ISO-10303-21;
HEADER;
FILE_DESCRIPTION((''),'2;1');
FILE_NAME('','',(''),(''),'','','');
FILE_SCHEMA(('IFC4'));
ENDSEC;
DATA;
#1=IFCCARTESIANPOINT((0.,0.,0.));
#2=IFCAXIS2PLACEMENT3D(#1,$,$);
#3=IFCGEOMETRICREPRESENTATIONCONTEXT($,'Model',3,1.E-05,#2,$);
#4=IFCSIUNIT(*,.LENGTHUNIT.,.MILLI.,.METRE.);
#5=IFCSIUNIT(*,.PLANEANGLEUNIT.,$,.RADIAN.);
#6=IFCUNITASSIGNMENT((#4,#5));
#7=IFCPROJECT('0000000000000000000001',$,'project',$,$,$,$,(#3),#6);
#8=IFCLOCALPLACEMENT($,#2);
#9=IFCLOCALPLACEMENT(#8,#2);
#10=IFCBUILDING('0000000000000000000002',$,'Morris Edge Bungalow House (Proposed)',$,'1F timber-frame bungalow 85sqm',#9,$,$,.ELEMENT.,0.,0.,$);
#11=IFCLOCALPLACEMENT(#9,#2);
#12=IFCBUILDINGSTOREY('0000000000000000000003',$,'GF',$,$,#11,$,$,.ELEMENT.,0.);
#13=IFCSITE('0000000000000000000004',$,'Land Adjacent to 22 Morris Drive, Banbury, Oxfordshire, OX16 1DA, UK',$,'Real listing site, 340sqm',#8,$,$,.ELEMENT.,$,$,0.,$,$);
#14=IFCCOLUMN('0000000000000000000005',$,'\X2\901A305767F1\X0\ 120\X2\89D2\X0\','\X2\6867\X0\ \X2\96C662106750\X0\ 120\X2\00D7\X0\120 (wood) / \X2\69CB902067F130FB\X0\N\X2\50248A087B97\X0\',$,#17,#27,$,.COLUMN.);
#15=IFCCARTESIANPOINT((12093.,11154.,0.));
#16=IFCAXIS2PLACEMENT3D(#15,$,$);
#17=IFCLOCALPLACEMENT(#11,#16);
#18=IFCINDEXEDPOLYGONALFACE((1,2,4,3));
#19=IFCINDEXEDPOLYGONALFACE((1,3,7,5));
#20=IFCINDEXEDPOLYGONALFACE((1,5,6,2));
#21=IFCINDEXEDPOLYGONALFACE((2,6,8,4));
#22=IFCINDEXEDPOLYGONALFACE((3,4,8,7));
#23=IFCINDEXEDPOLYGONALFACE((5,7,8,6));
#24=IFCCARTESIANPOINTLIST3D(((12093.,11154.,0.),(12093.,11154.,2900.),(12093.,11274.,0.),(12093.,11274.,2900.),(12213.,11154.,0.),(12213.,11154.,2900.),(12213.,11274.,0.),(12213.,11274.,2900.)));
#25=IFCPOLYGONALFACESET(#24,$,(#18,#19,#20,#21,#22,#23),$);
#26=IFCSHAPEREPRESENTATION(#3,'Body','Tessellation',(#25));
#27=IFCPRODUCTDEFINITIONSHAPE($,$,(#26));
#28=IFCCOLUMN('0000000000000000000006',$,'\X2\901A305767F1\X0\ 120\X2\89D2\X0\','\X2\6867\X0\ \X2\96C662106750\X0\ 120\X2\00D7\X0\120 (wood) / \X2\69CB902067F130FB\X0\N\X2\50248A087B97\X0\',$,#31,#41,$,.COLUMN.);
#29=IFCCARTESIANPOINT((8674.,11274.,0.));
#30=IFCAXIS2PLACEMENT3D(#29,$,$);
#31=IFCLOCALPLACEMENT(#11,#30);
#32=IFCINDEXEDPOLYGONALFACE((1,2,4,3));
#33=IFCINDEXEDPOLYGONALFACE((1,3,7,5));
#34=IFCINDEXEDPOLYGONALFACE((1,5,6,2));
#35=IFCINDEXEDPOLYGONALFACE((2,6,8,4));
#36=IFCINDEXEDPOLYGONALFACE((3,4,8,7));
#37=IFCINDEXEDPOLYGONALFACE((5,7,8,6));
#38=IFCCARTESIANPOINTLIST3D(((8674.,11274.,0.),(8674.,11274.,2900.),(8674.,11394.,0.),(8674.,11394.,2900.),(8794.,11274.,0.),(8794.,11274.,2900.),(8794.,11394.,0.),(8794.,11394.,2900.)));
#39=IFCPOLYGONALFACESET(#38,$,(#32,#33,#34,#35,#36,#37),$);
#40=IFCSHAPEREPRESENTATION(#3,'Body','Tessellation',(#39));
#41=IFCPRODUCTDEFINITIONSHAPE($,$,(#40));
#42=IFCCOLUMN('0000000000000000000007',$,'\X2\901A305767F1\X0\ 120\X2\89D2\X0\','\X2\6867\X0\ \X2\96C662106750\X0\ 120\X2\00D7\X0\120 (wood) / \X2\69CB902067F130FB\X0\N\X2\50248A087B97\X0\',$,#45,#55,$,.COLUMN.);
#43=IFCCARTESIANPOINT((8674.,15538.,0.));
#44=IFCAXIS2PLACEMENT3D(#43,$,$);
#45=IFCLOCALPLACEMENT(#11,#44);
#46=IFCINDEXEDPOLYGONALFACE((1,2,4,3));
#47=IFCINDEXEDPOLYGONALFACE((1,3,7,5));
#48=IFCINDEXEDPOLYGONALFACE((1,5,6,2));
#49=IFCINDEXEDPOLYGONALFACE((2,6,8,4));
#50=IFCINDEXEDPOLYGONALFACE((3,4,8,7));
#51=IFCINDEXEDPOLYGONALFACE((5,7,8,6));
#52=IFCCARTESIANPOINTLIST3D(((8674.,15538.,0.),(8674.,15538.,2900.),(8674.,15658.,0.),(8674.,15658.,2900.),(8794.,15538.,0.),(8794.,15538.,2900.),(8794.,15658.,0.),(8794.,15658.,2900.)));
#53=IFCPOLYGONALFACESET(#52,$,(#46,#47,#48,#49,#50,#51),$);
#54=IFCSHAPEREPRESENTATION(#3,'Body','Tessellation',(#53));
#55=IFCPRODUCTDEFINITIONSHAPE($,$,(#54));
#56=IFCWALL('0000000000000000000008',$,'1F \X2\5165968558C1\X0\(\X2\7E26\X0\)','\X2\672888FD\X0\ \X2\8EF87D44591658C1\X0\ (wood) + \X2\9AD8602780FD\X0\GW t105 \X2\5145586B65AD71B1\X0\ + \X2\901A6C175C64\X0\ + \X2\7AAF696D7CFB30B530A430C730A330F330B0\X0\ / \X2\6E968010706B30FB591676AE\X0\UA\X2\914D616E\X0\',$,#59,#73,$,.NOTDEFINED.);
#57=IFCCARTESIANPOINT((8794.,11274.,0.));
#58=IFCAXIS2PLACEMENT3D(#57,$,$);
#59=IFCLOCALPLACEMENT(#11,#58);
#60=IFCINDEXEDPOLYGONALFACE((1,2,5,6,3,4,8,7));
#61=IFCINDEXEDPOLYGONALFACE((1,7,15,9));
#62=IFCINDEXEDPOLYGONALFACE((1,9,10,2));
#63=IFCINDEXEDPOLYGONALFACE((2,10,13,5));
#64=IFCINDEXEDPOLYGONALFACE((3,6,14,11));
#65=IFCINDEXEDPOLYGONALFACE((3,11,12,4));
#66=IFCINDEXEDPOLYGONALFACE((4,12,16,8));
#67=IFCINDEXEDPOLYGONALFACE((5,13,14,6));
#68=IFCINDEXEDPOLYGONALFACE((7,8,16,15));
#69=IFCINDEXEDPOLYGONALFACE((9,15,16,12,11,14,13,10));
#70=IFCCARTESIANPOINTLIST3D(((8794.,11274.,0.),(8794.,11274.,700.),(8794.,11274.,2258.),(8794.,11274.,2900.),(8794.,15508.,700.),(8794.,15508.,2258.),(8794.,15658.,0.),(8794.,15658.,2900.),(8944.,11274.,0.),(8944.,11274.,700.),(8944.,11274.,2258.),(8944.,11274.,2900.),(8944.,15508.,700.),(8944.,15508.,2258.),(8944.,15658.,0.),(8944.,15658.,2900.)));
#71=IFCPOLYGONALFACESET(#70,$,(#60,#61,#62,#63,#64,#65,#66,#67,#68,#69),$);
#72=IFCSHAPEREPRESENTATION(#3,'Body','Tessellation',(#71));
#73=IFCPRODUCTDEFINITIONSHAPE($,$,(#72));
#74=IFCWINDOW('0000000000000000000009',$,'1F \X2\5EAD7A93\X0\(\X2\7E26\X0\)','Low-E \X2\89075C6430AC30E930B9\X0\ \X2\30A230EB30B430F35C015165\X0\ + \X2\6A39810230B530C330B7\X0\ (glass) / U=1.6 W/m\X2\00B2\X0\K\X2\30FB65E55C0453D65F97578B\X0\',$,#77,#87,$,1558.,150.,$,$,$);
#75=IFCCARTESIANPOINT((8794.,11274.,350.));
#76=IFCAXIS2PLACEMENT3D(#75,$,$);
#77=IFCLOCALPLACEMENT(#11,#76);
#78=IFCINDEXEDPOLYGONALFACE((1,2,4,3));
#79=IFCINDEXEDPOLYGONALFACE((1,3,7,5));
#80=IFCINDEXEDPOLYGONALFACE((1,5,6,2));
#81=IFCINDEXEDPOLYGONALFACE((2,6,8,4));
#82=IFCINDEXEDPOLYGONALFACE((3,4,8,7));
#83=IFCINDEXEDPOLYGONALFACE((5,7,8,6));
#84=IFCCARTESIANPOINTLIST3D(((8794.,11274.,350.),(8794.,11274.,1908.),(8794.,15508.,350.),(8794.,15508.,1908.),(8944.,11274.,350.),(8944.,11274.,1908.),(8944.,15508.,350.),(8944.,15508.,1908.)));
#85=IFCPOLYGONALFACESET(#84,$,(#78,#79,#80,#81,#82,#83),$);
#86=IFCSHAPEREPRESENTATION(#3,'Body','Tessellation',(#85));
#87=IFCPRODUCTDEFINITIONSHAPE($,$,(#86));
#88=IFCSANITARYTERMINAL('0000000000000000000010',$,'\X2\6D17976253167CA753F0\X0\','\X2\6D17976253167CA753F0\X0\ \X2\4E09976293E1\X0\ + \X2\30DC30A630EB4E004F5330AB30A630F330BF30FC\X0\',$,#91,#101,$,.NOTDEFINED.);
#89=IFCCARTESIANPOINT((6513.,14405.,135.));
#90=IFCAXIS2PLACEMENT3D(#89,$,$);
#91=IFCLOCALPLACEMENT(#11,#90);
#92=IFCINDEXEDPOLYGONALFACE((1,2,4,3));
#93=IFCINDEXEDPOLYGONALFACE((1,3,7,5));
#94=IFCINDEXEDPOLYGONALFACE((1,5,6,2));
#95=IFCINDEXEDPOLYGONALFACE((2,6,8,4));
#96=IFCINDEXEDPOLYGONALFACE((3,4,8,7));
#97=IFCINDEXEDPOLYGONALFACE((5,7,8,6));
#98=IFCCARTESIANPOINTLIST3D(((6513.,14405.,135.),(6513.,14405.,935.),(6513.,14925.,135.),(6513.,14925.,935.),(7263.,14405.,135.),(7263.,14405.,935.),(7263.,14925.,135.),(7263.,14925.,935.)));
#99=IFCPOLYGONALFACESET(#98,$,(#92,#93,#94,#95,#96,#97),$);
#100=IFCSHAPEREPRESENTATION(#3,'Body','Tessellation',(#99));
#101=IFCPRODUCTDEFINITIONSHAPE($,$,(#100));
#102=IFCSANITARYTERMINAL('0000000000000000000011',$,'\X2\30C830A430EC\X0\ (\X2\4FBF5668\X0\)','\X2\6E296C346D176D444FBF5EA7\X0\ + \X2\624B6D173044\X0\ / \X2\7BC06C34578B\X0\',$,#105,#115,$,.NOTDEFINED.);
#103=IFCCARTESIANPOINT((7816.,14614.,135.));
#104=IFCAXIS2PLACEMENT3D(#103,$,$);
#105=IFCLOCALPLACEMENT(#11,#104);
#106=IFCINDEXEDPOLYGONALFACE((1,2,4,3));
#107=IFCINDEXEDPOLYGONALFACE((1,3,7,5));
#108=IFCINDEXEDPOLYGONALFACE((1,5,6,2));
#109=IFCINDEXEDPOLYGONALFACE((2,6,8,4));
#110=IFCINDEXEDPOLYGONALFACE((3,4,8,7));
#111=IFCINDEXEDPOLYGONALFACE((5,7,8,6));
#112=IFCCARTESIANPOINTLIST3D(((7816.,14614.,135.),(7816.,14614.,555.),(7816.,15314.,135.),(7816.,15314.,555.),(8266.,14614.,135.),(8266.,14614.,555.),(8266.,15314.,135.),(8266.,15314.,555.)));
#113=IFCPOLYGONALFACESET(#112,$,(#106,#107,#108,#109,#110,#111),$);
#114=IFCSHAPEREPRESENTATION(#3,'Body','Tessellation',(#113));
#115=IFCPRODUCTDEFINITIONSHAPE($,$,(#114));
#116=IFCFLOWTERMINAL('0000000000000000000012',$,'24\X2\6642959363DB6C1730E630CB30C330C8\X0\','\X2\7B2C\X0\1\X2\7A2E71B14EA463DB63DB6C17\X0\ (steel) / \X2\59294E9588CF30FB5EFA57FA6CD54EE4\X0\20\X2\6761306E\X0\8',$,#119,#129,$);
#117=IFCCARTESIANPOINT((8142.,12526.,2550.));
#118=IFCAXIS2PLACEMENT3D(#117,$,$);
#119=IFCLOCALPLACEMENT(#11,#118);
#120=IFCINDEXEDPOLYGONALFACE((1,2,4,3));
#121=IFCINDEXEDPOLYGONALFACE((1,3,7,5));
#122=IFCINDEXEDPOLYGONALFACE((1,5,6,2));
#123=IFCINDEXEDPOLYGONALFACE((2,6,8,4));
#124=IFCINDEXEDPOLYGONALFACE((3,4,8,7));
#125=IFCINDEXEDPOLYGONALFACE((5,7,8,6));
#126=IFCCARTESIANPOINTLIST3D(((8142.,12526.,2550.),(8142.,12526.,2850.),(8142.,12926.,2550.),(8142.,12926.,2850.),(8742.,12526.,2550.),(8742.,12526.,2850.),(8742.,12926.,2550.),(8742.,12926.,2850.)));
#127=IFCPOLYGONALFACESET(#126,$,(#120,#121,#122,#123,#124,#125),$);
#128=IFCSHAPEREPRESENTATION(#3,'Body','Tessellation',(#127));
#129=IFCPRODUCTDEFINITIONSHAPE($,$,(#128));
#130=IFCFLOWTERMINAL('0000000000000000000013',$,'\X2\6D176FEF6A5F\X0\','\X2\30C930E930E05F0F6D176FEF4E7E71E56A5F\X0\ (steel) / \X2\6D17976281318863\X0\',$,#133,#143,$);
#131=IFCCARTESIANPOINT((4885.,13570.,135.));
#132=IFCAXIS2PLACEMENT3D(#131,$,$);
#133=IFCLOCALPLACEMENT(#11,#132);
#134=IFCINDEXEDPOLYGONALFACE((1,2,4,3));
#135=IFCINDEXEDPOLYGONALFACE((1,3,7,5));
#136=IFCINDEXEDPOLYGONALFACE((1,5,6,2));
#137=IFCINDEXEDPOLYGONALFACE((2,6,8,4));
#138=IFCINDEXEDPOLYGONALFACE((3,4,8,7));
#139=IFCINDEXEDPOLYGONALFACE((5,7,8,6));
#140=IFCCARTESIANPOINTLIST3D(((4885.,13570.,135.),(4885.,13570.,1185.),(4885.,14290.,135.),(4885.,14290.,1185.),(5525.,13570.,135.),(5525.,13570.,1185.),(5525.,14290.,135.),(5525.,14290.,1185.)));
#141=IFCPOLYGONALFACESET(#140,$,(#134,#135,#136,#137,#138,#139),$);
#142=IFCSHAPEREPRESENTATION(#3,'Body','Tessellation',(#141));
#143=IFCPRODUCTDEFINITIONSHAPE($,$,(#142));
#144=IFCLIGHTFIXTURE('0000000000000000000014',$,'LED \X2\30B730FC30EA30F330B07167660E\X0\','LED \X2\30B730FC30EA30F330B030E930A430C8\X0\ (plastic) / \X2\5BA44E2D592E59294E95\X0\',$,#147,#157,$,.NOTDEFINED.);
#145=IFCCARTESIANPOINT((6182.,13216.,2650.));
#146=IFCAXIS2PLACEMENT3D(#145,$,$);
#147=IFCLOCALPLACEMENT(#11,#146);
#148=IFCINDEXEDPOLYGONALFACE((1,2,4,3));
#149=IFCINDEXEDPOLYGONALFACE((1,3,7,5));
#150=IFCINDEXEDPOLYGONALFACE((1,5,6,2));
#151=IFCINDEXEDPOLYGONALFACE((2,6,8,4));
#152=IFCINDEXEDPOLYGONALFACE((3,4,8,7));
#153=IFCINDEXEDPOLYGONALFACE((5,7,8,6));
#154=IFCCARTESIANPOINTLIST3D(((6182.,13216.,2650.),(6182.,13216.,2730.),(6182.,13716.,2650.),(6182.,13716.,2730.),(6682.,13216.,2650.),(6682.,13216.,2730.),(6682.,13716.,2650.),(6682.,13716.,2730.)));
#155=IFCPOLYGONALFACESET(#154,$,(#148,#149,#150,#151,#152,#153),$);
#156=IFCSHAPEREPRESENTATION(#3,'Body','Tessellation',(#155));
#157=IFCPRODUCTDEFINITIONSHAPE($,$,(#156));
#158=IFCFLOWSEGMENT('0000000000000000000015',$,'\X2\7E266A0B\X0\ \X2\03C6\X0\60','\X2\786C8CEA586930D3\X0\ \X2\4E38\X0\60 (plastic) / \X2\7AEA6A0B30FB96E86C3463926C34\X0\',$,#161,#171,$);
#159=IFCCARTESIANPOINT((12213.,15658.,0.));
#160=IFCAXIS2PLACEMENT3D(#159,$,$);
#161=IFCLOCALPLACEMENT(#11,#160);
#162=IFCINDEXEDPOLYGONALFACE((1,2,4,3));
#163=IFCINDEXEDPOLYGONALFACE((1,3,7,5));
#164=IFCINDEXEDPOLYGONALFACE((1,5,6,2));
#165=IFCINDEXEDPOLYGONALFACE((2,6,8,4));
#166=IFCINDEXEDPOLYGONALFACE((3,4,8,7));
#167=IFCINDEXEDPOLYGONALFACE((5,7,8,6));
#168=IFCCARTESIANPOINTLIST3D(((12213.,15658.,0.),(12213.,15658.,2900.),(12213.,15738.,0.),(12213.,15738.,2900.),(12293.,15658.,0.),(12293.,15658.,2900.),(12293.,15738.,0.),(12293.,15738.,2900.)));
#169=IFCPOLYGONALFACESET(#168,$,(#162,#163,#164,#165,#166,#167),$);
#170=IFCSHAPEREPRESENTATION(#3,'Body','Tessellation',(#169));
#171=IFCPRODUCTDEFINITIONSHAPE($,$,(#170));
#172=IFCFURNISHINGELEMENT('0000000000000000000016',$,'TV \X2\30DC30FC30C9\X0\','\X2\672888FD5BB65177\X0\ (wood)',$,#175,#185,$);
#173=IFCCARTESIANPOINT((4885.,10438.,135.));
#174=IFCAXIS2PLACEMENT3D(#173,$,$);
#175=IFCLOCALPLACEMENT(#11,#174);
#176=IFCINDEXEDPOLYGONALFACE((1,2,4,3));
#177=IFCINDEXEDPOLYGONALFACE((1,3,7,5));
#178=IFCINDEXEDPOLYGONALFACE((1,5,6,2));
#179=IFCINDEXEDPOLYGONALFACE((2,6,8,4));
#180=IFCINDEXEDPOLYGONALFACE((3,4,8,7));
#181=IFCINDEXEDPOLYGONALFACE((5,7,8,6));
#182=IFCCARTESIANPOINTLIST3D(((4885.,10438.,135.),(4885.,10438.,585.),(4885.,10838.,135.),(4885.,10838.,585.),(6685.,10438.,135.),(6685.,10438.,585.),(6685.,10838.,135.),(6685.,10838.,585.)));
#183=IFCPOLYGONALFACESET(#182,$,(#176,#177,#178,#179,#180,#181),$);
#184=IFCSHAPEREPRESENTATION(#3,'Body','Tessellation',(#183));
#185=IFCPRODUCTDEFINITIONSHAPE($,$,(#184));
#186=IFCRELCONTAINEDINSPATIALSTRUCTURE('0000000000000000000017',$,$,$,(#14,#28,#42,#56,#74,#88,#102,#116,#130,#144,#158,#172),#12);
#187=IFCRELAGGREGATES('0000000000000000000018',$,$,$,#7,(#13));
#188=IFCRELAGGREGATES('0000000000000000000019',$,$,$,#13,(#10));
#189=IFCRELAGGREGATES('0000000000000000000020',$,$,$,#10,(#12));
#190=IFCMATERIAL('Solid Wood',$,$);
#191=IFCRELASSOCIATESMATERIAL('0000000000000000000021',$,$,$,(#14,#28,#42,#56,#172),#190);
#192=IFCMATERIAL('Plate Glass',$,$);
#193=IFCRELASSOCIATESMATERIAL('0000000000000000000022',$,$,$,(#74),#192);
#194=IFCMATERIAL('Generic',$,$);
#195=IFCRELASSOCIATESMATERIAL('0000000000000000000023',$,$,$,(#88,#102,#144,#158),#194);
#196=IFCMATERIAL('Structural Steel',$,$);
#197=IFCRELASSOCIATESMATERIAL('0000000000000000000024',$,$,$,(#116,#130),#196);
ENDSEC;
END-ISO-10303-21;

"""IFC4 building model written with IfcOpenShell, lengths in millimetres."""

from ifc_helpers import new_model, si_unit, frame, frame_2d, origin, place, context, project, spatial, rectangle, extrude, material, element, fill, save


model = new_model("IFC4")

# Units and contexts
model_context = context("Model", 3, precision=1e-05, world=origin())
ifc_project = project(units=[si_unit("LENGTHUNIT", "METRE", prefix="MILLI"), si_unit("PLANEANGLEUNIT", "RADIAN")], contexts=[model_context])

# Site, building, storey
site_placement = place(None, origin())
site = spatial("IfcSite", under=ifc_project, at=site_placement, Name="Land Adjacent to 22 Morris Drive, Banbury, Oxfordshire, OX16 1DA, UK", ObjectType="Real listing site, 340sqm", CompositionType="ELEMENT", RefElevation=0.0)
building_placement = place(site_placement, origin())
building = spatial("IfcBuilding", under=site, at=building_placement, Name="Morris Edge Bungalow House (Proposed)", ObjectType="1F timber-frame bungalow 85sqm", CompositionType="ELEMENT", ElevationOfRefHeight=0.0, ElevationOfTerrain=0.0)
storey_placement = place(building_placement, origin())
storey = spatial("IfcBuildingStorey", under=building, at=storey_placement, Name="GF", CompositionType="ELEMENT", Elevation=0.0)

# Columns
ifc_material_1 = material(Name="Solid Wood")
column_1_placement = place(storey_placement, frame((12093.0, 11154.0, 0.0)))
element("IfcColumn", 1, at=column_1_placement, inside=storey, material=ifc_material_1, Name="通し柱 120角", Description="桧 集成材 120×120 (wood) / 構造柱・N値計算", PredefinedType="COLUMN", context=model_context, shape_type="SweptSolid", body=[
    extrude(rectangle(XDim=120.0, YDim=120.0, at=frame_2d((60.0, 60.0))), frame((12093.0, 11154.0, 0.0)), (0.0, 0.0, 1.0), 2900.0),
])
column_2_placement = place(storey_placement, frame((8674.0, 11274.0, 0.0)))
element("IfcColumn", 2, at=column_2_placement, inside=storey, material=ifc_material_1, Name="通し柱 120角", Description="桧 集成材 120×120 (wood) / 構造柱・N値計算", PredefinedType="COLUMN", context=model_context, shape_type="SweptSolid", body=[
    extrude(rectangle(XDim=120.0, YDim=120.0, at=frame_2d((60.0, 60.0))), frame((8674.0, 11274.0, 0.0)), (0.0, 0.0, 1.0), 2900.0),
])
column_3_placement = place(storey_placement, frame((8674.0, 15538.0, 0.0)))
element("IfcColumn", 3, at=column_3_placement, inside=storey, material=ifc_material_1, Name="通し柱 120角", Description="桧 集成材 120×120 (wood) / 構造柱・N値計算", PredefinedType="COLUMN", context=model_context, shape_type="SweptSolid", body=[
    extrude(rectangle(XDim=120.0, YDim=120.0, at=frame_2d((60.0, 60.0))), frame((8674.0, 15538.0, 0.0)), (0.0, 0.0, 1.0), 2900.0),
])

# Wall, opening, window
wall_1_placement = place(storey_placement, frame((8794.0, 11274.0, 0.0)))
wall_1 = element("IfcWall", 4, at=wall_1_placement, inside=storey, material=ifc_material_1, Name="1F 入隅壁(縦)", Description="木製 軸組外壁 (wood) + 高性能GW t105 充填断熱 + 通気層 + 窯業系サイディング / 準耐火・外皮UA配慮", PredefinedType="NOTDEFINED", context=model_context, shape_type="SweptSolid", body=[
    extrude(rectangle(XDim=150.0, YDim=4384.0, at=frame_2d((75.0, 2192.0))), frame((8794.0, 11274.0, 0.0)), (0.0, 0.0, 1.0), 2900.0),
])
opening_placement = place(storey_placement, frame((8794.0, 11274.0, 350.0)))
opening = element("IfcOpeningElement", 5, at=opening_placement, cuts=wall_1, PredefinedType="NOTDEFINED", context=model_context, shape_type="SweptSolid", body=[
    extrude(rectangle(XDim=150.0, YDim=4234.0, at=frame_2d((75.0, 2117.0))), frame((8794.0, 11274.0, 350.0)), (0.0, 0.0, 1.0), 1558.0),
])
ifc_material_2 = material(Name="Plate Glass")
window_placement = place(storey_placement, frame((8794.0, 11274.0, 350.0)))
window = element("IfcWindow", 6, at=window_placement, inside=storey, material=ifc_material_2, Name="1F 庭窓(縦)", Description="Low-E 複層ガラス アルゴン封入 + 樹脂サッシ (glass) / U=1.6 W/m²K・日射取得型", OverallHeight=1558.0, OverallWidth=150.0, context=model_context, shape_type="SweptSolid", body=[
    extrude(rectangle(XDim=150.0, YDim=4234.0, at=frame_2d((75.0, 2117.0))), frame((8794.0, 11274.0, 350.0)), (0.0, 0.0, 1.0), 1558.0),
])
fill(opening, window)

# Sanitary terminals
ifc_material_3 = material(Name="Generic")
sanitary_terminal_1_placement = place(storey_placement, frame((6513.0, 14405.0, 135.0)))
element("IfcSanitaryTerminal", 7, at=sanitary_terminal_1_placement, inside=storey, material=ifc_material_3, Name="洗面化粧台", Description="洗面化粧台 三面鏡 + ボウル一体カウンター", PredefinedType="NOTDEFINED", context=model_context, shape_type="SweptSolid", body=[
    extrude(rectangle(XDim=750.0, YDim=520.0, at=frame_2d((375.0, 260.0))), frame((6513.0, 14405.0, 135.0)), (0.0, 0.0, 1.0), 800.0),
])
sanitary_terminal_2_placement = place(storey_placement, frame((7816.0, 14614.0, 135.0)))
element("IfcSanitaryTerminal", 8, at=sanitary_terminal_2_placement, inside=storey, material=ifc_material_3, Name="トイレ (便器)", Description="温水洗浄便座 + 手洗い / 節水型", PredefinedType="NOTDEFINED", context=model_context, shape_type="SweptSolid", body=[
    extrude(rectangle(XDim=450.0, YDim=700.0, at=frame_2d((225.0, 350.0))), frame((7816.0, 14614.0, 135.0)), (0.0, 0.0, 1.0), 420.0),
])

# Flow terminals
ifc_material_4 = material(Name="Structural Steel")
flow_terminal_1_placement = place(storey_placement, frame((8142.0, 12526.0, 2550.0)))
element("IfcFlowTerminal", 9, at=flow_terminal_1_placement, inside=storey, material=ifc_material_4, Name="24時間換気ユニット", Description="第1種熱交換換気 (steel) / 天井裏・建基法令20条の8", context=model_context, shape_type="SweptSolid", body=[
    extrude(rectangle(XDim=600.0, YDim=400.0, at=frame_2d((300.0, 200.0))), frame((8142.0, 12526.0, 2550.0)), (0.0, 0.0, 1.0), 300.0),
])
flow_terminal_2_placement = place(storey_placement, frame((4885.0, 13570.0, 135.0)))
element("IfcFlowTerminal", 10, at=flow_terminal_2_placement, inside=storey, material=ifc_material_4, Name="洗濯機", Description="ドラム式洗濯乾燥機 (steel) / 洗面脱衣", context=model_context, shape_type="SweptSolid", body=[
    extrude(rectangle(XDim=640.0, YDim=720.0, at=frame_2d((320.0, 360.0))), frame((4885.0, 13570.0, 135.0)), (0.0, 0.0, 1.0), 1050.0),
])

# Light fixture
light_fixture_placement = place(storey_placement, frame((6182.0, 13216.0, 2650.0)))
element("IfcLightFixture", 11, at=light_fixture_placement, inside=storey, material=ifc_material_3, Name="LED シーリング照明", Description="LED シーリングライト (plastic) / 室中央天井", PredefinedType="NOTDEFINED", context=model_context, shape_type="SweptSolid", body=[
    extrude(rectangle(XDim=500.0, YDim=500.0, at=frame_2d((250.0, 250.0))), frame((6182.0, 13216.0, 2650.0)), (0.0, 0.0, 1.0), 80.0),
])

# Flow segment
flow_segment_placement = place(storey_placement, frame((12213.0, 15658.0, 0.0)))
element("IfcFlowSegment", 12, at=flow_segment_placement, inside=storey, material=ifc_material_3, Name="縦樋 φ60", Description="硬質塩ビ 丸60 (plastic) / 竪樋・雨水排水", context=model_context, shape_type="SweptSolid", body=[
    extrude(rectangle(XDim=80.0, YDim=80.0, at=frame_2d((40.0, 40.0))), frame((12213.0, 15658.0, 0.0)), (0.0, 0.0, 1.0), 2900.0),
])

# Furnishing element
furnishing_placement = place(storey_placement, frame((4885.0, 10438.0, 135.0)))
element("IfcFurnishingElement", 13, at=furnishing_placement, inside=storey, material=ifc_material_1, Name="TV ボード", Description="木製家具 (wood)", context=model_context, shape_type="SweptSolid", body=[
    extrude(rectangle(XDim=1800.0, YDim=400.0, at=frame_2d((900.0, 200.0))), frame((4885.0, 10438.0, 135.0)), (0.0, 0.0, 1.0), 450.0),
])

save(model, "model.ifc")
